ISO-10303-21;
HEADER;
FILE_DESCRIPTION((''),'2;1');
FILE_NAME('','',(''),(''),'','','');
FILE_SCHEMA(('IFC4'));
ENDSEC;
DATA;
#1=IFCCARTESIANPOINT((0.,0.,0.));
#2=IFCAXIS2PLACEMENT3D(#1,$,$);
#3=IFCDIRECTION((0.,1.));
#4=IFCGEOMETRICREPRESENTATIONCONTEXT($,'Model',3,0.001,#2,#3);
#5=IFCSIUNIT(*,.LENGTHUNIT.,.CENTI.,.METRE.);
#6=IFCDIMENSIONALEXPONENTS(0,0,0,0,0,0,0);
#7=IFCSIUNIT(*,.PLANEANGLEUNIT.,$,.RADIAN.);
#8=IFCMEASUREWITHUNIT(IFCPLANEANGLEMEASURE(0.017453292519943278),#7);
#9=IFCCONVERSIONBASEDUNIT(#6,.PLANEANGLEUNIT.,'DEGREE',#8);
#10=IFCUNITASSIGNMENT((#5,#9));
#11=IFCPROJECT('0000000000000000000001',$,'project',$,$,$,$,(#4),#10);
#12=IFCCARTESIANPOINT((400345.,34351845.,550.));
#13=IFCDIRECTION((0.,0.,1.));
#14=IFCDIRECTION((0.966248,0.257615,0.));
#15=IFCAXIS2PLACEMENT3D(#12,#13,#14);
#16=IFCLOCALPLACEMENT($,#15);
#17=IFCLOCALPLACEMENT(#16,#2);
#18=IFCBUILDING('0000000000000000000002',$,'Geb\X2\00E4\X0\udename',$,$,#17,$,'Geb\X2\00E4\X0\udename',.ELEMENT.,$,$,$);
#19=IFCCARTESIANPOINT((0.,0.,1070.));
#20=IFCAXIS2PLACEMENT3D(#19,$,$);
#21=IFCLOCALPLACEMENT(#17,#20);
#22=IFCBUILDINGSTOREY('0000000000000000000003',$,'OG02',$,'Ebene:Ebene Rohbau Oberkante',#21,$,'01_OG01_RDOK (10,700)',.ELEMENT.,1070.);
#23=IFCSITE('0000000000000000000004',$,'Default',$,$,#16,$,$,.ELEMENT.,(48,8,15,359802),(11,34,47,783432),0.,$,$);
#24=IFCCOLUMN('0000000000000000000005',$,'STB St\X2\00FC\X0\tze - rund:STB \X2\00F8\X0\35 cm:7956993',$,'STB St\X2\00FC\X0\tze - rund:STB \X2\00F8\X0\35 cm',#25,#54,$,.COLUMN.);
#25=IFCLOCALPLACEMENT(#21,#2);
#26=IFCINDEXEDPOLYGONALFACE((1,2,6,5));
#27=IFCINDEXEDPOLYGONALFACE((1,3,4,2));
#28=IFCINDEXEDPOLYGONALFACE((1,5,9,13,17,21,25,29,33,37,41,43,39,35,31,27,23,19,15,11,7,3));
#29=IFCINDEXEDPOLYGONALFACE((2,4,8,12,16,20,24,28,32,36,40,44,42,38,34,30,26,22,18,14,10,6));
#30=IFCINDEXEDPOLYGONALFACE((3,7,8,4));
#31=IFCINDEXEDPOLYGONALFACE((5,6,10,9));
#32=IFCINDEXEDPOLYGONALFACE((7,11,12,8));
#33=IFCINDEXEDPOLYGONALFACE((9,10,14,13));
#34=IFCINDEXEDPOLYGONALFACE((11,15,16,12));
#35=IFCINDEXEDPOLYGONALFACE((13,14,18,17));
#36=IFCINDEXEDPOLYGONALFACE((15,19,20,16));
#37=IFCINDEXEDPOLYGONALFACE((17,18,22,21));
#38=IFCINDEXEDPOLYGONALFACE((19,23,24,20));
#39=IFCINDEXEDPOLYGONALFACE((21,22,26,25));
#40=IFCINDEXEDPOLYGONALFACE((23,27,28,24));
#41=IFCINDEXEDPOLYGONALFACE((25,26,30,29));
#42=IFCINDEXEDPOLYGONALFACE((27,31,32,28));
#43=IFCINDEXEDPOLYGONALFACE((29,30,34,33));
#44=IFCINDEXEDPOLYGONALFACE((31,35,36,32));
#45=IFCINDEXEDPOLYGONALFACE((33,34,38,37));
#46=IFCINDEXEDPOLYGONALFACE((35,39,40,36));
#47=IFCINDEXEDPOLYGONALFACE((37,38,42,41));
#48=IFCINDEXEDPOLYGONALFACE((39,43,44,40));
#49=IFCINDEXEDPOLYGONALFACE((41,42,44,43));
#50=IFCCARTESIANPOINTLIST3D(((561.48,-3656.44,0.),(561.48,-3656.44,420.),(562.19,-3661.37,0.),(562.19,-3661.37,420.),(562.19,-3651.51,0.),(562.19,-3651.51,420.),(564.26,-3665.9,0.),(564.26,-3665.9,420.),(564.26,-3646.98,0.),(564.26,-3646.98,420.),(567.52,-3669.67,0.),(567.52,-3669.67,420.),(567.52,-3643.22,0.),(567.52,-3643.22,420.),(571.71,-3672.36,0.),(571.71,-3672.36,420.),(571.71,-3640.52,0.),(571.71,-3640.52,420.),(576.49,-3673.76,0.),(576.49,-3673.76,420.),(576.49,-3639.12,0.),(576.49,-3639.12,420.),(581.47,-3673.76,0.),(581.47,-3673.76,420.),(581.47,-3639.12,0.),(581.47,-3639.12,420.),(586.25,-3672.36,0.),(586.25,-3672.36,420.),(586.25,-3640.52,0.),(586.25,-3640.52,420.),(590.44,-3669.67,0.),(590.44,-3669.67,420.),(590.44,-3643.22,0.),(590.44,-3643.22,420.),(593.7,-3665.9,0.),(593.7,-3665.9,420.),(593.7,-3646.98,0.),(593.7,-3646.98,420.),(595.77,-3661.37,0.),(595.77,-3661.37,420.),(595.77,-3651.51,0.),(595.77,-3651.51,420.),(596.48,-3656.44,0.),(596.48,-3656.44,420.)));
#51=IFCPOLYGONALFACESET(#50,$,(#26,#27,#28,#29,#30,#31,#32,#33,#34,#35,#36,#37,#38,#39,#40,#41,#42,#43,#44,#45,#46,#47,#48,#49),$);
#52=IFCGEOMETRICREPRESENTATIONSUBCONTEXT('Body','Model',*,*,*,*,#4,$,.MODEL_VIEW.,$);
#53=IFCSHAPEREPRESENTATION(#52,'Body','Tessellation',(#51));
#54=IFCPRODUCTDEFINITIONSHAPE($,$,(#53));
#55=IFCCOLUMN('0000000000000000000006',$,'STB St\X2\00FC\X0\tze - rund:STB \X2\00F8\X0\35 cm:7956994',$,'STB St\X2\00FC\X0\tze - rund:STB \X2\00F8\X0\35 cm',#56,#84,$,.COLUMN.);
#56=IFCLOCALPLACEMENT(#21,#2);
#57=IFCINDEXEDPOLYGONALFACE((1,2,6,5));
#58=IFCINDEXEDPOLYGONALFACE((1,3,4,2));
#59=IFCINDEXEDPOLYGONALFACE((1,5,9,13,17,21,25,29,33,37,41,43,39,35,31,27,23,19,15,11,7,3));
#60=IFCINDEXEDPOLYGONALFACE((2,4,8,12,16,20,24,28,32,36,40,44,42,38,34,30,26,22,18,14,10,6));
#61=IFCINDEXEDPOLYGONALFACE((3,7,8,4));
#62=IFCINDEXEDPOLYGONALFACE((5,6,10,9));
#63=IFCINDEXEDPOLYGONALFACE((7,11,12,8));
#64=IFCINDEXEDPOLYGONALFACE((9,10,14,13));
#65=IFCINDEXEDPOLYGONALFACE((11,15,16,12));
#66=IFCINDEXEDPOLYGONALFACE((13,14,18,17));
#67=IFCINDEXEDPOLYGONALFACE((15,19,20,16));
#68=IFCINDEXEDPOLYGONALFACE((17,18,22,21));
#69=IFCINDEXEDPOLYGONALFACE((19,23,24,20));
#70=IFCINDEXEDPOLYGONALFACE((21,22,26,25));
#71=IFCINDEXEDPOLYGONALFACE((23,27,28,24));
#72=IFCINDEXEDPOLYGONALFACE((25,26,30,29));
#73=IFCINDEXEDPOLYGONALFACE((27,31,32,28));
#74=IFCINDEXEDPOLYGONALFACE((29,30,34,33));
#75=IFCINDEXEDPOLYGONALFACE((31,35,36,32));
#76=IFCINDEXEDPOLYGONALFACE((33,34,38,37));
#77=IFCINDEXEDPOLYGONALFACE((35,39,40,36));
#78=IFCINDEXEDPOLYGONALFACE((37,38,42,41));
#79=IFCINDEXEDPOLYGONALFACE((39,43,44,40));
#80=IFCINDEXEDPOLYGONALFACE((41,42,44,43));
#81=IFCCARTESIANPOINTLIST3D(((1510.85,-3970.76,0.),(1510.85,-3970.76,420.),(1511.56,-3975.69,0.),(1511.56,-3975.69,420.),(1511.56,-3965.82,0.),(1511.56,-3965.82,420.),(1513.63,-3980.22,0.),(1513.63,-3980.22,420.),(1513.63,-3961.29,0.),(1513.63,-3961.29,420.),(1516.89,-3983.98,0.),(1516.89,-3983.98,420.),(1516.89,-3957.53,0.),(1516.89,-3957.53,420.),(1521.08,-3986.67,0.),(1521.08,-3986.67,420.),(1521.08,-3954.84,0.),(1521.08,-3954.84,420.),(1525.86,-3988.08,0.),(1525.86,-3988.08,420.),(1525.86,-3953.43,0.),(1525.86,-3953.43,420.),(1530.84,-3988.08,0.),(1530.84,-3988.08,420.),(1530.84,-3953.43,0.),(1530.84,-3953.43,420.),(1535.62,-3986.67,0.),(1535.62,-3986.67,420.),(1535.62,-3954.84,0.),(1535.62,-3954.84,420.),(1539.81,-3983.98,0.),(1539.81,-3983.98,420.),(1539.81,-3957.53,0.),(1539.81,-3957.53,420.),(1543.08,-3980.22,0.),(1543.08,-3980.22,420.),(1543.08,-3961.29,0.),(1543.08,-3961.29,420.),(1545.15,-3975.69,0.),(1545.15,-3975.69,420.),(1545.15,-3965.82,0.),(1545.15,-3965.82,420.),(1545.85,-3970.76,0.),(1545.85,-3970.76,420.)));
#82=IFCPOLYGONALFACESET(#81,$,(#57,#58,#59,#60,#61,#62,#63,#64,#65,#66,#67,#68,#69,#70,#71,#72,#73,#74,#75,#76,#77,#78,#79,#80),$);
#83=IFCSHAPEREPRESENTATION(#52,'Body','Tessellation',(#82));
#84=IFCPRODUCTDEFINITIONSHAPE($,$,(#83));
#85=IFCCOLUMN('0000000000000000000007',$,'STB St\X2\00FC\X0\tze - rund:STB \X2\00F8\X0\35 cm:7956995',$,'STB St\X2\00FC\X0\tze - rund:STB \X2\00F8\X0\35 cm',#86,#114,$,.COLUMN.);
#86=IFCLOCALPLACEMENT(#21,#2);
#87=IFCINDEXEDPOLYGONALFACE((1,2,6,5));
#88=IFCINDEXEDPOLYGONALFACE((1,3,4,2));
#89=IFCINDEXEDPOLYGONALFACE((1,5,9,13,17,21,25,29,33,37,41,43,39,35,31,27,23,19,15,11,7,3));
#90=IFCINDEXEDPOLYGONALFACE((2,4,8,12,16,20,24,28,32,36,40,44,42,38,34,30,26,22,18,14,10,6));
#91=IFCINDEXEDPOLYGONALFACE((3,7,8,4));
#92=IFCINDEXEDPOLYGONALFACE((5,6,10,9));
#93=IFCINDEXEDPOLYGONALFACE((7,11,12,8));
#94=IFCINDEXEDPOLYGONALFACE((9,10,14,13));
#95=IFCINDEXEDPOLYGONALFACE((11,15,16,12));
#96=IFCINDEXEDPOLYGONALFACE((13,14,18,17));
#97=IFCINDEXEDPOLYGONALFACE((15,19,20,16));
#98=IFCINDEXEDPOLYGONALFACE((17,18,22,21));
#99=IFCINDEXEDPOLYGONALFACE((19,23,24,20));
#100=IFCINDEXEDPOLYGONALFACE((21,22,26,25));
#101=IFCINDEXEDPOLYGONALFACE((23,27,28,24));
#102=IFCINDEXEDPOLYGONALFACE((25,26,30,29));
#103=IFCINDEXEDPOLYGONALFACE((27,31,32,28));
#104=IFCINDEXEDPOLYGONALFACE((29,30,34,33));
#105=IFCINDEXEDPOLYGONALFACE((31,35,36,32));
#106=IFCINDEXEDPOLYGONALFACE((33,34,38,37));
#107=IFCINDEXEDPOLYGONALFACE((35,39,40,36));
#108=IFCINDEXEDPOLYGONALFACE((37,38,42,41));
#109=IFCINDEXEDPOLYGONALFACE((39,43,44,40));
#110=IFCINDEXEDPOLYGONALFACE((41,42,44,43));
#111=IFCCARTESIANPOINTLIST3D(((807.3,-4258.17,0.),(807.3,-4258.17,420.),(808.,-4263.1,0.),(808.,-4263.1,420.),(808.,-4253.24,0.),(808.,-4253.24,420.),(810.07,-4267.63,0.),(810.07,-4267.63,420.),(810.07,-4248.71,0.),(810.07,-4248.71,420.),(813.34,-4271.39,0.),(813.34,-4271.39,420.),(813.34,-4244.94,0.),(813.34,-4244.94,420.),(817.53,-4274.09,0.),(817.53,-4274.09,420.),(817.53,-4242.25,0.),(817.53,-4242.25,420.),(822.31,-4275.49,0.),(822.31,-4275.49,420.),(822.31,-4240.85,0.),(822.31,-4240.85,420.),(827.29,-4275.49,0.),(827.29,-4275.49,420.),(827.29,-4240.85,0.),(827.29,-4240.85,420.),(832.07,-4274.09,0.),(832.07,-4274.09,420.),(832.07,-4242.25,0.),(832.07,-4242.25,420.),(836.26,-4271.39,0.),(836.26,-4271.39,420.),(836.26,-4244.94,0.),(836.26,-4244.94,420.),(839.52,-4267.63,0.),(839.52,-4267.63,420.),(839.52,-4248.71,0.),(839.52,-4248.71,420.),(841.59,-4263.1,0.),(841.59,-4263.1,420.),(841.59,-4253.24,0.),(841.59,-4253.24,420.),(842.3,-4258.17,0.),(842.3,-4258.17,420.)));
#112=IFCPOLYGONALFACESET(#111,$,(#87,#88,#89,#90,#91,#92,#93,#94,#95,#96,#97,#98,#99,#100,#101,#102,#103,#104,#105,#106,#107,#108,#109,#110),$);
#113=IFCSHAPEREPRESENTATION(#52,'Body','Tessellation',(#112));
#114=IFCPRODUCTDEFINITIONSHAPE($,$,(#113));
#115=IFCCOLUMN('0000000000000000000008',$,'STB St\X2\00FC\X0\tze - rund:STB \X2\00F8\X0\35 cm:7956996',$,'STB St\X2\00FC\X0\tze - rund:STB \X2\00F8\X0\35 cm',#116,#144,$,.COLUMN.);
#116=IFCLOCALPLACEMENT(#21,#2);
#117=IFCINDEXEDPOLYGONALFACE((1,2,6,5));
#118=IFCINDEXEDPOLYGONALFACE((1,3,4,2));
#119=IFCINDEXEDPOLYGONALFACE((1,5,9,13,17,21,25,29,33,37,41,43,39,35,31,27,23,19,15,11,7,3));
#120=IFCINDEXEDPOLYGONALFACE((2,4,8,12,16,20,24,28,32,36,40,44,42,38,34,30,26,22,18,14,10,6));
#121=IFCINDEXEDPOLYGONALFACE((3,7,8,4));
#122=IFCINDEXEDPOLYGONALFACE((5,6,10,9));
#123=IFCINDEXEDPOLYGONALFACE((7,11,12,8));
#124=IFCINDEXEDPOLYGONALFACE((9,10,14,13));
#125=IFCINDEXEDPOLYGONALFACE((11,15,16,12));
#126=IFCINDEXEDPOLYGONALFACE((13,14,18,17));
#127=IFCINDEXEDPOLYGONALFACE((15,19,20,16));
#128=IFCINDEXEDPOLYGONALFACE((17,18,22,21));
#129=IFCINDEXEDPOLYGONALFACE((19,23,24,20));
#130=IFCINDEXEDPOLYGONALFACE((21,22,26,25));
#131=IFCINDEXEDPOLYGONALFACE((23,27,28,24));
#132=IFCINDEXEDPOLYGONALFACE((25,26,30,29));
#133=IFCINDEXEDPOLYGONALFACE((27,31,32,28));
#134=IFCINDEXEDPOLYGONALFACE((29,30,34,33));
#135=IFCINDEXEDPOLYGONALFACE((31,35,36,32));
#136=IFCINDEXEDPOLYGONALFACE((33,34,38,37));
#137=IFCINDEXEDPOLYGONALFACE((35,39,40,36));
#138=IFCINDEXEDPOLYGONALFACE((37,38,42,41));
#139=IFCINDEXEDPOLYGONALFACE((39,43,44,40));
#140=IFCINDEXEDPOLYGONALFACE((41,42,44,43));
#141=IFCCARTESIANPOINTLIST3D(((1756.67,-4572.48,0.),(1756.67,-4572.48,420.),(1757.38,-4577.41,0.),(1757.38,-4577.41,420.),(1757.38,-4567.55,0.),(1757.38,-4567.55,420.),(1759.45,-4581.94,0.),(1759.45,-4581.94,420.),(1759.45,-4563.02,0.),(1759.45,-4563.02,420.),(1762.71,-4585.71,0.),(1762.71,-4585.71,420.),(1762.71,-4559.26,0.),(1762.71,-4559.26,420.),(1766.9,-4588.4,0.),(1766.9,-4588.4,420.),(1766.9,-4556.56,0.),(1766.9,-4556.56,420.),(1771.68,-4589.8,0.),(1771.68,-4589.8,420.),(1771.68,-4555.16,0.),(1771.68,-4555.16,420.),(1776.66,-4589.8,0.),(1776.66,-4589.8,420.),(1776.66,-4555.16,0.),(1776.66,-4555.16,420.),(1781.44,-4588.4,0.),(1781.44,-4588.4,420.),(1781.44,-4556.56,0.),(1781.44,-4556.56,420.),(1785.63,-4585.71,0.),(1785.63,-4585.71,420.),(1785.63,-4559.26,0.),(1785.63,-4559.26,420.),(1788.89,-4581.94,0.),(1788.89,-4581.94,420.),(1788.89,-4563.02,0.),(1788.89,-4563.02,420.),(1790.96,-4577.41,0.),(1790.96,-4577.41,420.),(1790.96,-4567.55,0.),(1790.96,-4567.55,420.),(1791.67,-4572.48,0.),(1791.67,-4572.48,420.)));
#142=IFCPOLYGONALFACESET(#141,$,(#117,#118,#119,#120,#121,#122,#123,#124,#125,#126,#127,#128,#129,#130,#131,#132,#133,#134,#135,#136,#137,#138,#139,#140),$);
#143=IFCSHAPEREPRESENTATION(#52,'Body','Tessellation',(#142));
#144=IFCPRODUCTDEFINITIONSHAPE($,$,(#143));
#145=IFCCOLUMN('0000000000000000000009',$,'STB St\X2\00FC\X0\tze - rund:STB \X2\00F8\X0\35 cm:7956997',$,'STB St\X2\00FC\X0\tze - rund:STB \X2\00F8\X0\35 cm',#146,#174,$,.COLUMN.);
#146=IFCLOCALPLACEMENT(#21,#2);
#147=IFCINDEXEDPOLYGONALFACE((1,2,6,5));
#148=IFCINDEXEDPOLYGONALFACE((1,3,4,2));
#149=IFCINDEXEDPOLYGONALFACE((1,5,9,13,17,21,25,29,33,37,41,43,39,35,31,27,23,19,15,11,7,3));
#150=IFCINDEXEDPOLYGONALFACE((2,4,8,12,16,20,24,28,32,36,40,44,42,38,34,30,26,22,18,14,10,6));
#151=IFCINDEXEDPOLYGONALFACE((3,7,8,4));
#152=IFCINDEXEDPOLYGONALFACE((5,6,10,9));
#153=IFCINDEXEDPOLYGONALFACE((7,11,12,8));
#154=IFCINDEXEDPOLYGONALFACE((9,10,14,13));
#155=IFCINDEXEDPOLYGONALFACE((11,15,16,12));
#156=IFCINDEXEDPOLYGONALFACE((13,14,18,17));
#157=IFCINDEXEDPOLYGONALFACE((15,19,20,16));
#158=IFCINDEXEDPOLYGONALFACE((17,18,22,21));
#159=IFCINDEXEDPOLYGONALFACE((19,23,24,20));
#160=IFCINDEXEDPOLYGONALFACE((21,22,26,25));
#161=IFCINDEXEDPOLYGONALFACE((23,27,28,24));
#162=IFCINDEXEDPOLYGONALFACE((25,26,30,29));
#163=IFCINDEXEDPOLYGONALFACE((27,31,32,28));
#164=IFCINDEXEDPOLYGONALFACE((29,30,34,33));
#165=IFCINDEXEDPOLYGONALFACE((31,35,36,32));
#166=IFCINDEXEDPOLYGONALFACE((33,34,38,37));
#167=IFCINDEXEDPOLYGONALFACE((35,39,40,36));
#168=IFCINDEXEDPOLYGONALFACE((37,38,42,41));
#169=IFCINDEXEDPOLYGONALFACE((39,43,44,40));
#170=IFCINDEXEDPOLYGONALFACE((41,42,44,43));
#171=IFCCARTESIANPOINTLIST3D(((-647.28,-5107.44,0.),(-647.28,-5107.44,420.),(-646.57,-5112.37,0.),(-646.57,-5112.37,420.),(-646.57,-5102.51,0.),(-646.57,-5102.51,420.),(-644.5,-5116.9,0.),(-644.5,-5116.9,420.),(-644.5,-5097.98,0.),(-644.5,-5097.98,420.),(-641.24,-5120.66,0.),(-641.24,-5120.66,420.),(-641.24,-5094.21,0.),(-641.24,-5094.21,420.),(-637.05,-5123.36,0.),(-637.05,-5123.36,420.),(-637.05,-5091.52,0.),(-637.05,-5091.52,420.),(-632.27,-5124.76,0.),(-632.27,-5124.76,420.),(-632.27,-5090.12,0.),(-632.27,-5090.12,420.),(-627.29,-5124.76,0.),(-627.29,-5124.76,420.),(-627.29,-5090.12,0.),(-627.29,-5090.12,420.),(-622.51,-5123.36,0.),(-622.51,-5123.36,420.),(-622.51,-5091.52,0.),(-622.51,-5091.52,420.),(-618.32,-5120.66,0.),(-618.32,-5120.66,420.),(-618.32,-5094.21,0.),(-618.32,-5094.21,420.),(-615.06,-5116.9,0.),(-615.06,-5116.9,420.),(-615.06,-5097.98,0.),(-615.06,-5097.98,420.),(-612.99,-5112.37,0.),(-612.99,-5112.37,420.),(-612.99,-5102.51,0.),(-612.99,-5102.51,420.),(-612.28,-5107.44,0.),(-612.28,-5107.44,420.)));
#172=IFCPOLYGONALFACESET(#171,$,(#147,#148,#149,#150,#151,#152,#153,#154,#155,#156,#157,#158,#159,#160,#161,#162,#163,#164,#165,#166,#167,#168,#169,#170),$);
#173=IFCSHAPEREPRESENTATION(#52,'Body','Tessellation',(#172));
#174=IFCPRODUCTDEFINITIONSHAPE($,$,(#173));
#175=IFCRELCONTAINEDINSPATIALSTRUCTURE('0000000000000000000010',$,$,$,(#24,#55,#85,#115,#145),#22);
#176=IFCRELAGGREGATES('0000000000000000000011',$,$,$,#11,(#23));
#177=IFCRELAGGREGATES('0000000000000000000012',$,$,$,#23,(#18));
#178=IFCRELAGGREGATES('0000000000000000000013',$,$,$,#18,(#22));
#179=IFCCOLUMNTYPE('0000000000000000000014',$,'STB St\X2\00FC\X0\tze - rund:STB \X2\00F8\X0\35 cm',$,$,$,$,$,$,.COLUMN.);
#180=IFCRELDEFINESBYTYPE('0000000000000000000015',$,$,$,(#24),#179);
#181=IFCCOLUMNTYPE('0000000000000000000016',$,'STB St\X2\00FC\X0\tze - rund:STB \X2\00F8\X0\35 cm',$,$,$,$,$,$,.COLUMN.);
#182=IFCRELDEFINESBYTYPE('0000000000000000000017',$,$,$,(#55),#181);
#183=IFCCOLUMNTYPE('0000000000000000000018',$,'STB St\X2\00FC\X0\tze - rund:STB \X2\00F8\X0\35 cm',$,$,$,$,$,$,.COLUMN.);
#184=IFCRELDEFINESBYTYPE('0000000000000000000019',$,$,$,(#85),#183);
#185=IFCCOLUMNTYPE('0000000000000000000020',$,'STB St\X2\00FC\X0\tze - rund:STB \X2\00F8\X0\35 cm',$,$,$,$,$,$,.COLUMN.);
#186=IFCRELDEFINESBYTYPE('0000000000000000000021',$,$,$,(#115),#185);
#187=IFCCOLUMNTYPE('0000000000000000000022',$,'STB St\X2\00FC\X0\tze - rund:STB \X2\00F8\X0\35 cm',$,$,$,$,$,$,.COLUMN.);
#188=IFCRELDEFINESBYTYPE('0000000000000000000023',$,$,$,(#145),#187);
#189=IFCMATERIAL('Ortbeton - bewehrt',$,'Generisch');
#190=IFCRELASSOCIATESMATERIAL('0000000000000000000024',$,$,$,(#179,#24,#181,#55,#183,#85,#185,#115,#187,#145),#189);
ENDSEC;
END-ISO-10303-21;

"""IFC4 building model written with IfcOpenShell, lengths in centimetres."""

from ifc_helpers import new_model, entity, si_unit, converted_unit, direction, frame, origin, place, context, subcontext, project, spatial, arc, indexed_curve, outline, extrude, source, transform, mapped, material, type_object, type_shapes, element, save


model = new_model("IFC4")

# Units and contexts
model_context = context("Model", 3, precision=0.001, world=origin(), true_north=direction((0.0, 1.0)))
body_context = subcontext(model_context, "Body", "Model", "MODEL_VIEW")
ifc_project = project(units=[si_unit("LENGTHUNIT", "METRE", prefix="CENTI"), converted_unit("PLANEANGLEUNIT", "DEGREE", entity("IfcPlaneAngleMeasure", 0.017453292519943278), si_unit("PLANEANGLEUNIT", "RADIAN"), dimensions=[0, 0, 0, 0, 0, 0, 0])], contexts=[model_context])

# Site, building, storey
site_placement = place(None, frame((400345.0, 34351845.0, 550.0), z_axis=(0.0, 0.0, 1.0), x_axis=(0.966248, 0.257615, 0.0)))
site = spatial("IfcSite", under=ifc_project, at=site_placement, Name="Default", CompositionType="ELEMENT", RefLatitude=(48, 8, 15, 359802), RefLongitude=(11, 34, 47, 783432), RefElevation=0.0)
building_placement = place(site_placement, origin())
building = spatial("IfcBuilding", under=site, at=building_placement, Name="Gebäudename", LongName="Gebäudename", CompositionType="ELEMENT")
storey_placement = place(building_placement, frame((0.0, 0.0, 1070.0)))
storey = spatial("IfcBuildingStorey", under=building, at=storey_placement, Name="OG02", ObjectType="Ebene:Ebene Rohbau Oberkante", LongName="01_OG01_RDOK (10,700)", CompositionType="ELEMENT", Elevation=1070.0)

# Columns
ifc_material = material(Name="Ortbeton - bewehrt", Category="Generisch")
column_type_1 = type_object("IfcColumnType", Name="STB Stütze - rund:STB ø35 cm", PredefinedType="COLUMN", material=ifc_material)
shared_shape_1 = source(origin(), body_context, "Body", "SweptSolid", [
    extrude(outline(indexed_curve([(-17.5, 0.0), (0.0, -17.5), (17.5, 0.0), (0.0, 17.5)], segments=[arc(1, 2, 3), arc(3, 4, 1)], self_intersect=False)), frame((578.98, -3656.44, 1070.0)), (0.0, 0.0, 1.0), 420.0),
])
type_shapes(column_type_1, [shared_shape_1])
column_1_placement = place(storey_placement, frame((0.0, 0.0, -1070.0)))
element("IfcColumn", 1, at=column_1_placement, inside=storey, type_object=column_type_1, material=ifc_material, Name="STB Stütze - rund:STB ø35 cm:7956993", ObjectType="STB Stütze - rund:STB ø35 cm", PredefinedType="COLUMN", context=body_context, shape_type="MappedRepresentation", body=[
    mapped(shared_shape_1, transform((0.0, 0.0, 0.0), scale=1.0)),
])
column_type_2 = type_object("IfcColumnType", Name="STB Stütze - rund:STB ø35 cm", PredefinedType="COLUMN", material=ifc_material)
shared_shape_2 = source(origin(), body_context, "Body", "SweptSolid", [
    extrude(outline(indexed_curve([(-17.5, 0.0), (0.0, -17.5), (17.5, 0.0), (0.0, 17.5)], segments=[arc(1, 2, 3), arc(3, 4, 1)], self_intersect=False)), frame((1528.35, -3970.76, 1070.0)), (0.0, 0.0, 1.0), 420.0),
])
type_shapes(column_type_2, [shared_shape_2])
column_2_placement = place(storey_placement, frame((0.0, 0.0, -1070.0)))
element("IfcColumn", 2, at=column_2_placement, inside=storey, type_object=column_type_2, material=ifc_material, Name="STB Stütze - rund:STB ø35 cm:7956994", ObjectType="STB Stütze - rund:STB ø35 cm", PredefinedType="COLUMN", context=body_context, shape_type="MappedRepresentation", body=[
    mapped(shared_shape_2, transform((0.0, 0.0, 0.0), scale=1.0)),
])
column_type_3 = type_object("IfcColumnType", Name="STB Stütze - rund:STB ø35 cm", PredefinedType="COLUMN", material=ifc_material)
shared_shape_3 = source(origin(), body_context, "Body", "SweptSolid", [
    extrude(outline(indexed_curve([(-17.5, 0.0), (0.0, -17.5), (17.5, 0.0), (0.0, 17.5)], segments=[arc(1, 2, 3), arc(3, 4, 1)], self_intersect=False)), frame((824.8, -4258.17, 1070.0)), (0.0, 0.0, 1.0), 420.0),
])
type_shapes(column_type_3, [shared_shape_3])
column_3_placement = place(storey_placement, frame((0.0, 0.0, -1070.0)))
element("IfcColumn", 3, at=column_3_placement, inside=storey, type_object=column_type_3, material=ifc_material, Name="STB Stütze - rund:STB ø35 cm:7956995", ObjectType="STB Stütze - rund:STB ø35 cm", PredefinedType="COLUMN", context=body_context, shape_type="MappedRepresentation", body=[
    mapped(shared_shape_3, transform((0.0, 0.0, 0.0), scale=1.0)),
])
column_type_4 = type_object("IfcColumnType", Name="STB Stütze - rund:STB ø35 cm", PredefinedType="COLUMN", material=ifc_material)
shared_shape_4 = source(origin(), body_context, "Body", "SweptSolid", [
    extrude(outline(indexed_curve([(-17.5, 0.0), (0.0, -17.5), (17.5, 0.0), (0.0, 17.5)], segments=[arc(1, 2, 3), arc(3, 4, 1)], self_intersect=False)), frame((1774.17, -4572.48, 1070.0)), (0.0, 0.0, 1.0), 420.0),
])
type_shapes(column_type_4, [shared_shape_4])
column_4_placement = place(storey_placement, frame((0.0, 0.0, -1070.0)))
element("IfcColumn", 4, at=column_4_placement, inside=storey, type_object=column_type_4, material=ifc_material, Name="STB Stütze - rund:STB ø35 cm:7956996", ObjectType="STB Stütze - rund:STB ø35 cm", PredefinedType="COLUMN", context=body_context, shape_type="MappedRepresentation", body=[
    mapped(shared_shape_4, transform((0.0, 0.0, 0.0), scale=1.0)),
])
column_type_5 = type_object("IfcColumnType", Name="STB Stütze - rund:STB ø35 cm", PredefinedType="COLUMN", material=ifc_material)
shared_shape_5 = source(origin(), body_context, "Body", "SweptSolid", [
    extrude(outline(indexed_curve([(-17.5, 0.0), (0.0, -17.5), (17.5, 0.0), (0.0, 17.5)], segments=[arc(1, 2, 3), arc(3, 4, 1)], self_intersect=False)), frame((-629.78, -5107.44, 1070.0)), (0.0, 0.0, 1.0), 420.0),
])
type_shapes(column_type_5, [shared_shape_5])
column_5_placement = place(storey_placement, frame((0.0, 0.0, -1070.0)))
element("IfcColumn", 5, at=column_5_placement, inside=storey, type_object=column_type_5, material=ifc_material, Name="STB Stütze - rund:STB ø35 cm:7956997", ObjectType="STB Stütze - rund:STB ø35 cm", PredefinedType="COLUMN", context=body_context, shape_type="MappedRepresentation", body=[
    mapped(shared_shape_5, transform((0.0, 0.0, 0.0), scale=1.0)),
])

save(model, "model.ifc")
